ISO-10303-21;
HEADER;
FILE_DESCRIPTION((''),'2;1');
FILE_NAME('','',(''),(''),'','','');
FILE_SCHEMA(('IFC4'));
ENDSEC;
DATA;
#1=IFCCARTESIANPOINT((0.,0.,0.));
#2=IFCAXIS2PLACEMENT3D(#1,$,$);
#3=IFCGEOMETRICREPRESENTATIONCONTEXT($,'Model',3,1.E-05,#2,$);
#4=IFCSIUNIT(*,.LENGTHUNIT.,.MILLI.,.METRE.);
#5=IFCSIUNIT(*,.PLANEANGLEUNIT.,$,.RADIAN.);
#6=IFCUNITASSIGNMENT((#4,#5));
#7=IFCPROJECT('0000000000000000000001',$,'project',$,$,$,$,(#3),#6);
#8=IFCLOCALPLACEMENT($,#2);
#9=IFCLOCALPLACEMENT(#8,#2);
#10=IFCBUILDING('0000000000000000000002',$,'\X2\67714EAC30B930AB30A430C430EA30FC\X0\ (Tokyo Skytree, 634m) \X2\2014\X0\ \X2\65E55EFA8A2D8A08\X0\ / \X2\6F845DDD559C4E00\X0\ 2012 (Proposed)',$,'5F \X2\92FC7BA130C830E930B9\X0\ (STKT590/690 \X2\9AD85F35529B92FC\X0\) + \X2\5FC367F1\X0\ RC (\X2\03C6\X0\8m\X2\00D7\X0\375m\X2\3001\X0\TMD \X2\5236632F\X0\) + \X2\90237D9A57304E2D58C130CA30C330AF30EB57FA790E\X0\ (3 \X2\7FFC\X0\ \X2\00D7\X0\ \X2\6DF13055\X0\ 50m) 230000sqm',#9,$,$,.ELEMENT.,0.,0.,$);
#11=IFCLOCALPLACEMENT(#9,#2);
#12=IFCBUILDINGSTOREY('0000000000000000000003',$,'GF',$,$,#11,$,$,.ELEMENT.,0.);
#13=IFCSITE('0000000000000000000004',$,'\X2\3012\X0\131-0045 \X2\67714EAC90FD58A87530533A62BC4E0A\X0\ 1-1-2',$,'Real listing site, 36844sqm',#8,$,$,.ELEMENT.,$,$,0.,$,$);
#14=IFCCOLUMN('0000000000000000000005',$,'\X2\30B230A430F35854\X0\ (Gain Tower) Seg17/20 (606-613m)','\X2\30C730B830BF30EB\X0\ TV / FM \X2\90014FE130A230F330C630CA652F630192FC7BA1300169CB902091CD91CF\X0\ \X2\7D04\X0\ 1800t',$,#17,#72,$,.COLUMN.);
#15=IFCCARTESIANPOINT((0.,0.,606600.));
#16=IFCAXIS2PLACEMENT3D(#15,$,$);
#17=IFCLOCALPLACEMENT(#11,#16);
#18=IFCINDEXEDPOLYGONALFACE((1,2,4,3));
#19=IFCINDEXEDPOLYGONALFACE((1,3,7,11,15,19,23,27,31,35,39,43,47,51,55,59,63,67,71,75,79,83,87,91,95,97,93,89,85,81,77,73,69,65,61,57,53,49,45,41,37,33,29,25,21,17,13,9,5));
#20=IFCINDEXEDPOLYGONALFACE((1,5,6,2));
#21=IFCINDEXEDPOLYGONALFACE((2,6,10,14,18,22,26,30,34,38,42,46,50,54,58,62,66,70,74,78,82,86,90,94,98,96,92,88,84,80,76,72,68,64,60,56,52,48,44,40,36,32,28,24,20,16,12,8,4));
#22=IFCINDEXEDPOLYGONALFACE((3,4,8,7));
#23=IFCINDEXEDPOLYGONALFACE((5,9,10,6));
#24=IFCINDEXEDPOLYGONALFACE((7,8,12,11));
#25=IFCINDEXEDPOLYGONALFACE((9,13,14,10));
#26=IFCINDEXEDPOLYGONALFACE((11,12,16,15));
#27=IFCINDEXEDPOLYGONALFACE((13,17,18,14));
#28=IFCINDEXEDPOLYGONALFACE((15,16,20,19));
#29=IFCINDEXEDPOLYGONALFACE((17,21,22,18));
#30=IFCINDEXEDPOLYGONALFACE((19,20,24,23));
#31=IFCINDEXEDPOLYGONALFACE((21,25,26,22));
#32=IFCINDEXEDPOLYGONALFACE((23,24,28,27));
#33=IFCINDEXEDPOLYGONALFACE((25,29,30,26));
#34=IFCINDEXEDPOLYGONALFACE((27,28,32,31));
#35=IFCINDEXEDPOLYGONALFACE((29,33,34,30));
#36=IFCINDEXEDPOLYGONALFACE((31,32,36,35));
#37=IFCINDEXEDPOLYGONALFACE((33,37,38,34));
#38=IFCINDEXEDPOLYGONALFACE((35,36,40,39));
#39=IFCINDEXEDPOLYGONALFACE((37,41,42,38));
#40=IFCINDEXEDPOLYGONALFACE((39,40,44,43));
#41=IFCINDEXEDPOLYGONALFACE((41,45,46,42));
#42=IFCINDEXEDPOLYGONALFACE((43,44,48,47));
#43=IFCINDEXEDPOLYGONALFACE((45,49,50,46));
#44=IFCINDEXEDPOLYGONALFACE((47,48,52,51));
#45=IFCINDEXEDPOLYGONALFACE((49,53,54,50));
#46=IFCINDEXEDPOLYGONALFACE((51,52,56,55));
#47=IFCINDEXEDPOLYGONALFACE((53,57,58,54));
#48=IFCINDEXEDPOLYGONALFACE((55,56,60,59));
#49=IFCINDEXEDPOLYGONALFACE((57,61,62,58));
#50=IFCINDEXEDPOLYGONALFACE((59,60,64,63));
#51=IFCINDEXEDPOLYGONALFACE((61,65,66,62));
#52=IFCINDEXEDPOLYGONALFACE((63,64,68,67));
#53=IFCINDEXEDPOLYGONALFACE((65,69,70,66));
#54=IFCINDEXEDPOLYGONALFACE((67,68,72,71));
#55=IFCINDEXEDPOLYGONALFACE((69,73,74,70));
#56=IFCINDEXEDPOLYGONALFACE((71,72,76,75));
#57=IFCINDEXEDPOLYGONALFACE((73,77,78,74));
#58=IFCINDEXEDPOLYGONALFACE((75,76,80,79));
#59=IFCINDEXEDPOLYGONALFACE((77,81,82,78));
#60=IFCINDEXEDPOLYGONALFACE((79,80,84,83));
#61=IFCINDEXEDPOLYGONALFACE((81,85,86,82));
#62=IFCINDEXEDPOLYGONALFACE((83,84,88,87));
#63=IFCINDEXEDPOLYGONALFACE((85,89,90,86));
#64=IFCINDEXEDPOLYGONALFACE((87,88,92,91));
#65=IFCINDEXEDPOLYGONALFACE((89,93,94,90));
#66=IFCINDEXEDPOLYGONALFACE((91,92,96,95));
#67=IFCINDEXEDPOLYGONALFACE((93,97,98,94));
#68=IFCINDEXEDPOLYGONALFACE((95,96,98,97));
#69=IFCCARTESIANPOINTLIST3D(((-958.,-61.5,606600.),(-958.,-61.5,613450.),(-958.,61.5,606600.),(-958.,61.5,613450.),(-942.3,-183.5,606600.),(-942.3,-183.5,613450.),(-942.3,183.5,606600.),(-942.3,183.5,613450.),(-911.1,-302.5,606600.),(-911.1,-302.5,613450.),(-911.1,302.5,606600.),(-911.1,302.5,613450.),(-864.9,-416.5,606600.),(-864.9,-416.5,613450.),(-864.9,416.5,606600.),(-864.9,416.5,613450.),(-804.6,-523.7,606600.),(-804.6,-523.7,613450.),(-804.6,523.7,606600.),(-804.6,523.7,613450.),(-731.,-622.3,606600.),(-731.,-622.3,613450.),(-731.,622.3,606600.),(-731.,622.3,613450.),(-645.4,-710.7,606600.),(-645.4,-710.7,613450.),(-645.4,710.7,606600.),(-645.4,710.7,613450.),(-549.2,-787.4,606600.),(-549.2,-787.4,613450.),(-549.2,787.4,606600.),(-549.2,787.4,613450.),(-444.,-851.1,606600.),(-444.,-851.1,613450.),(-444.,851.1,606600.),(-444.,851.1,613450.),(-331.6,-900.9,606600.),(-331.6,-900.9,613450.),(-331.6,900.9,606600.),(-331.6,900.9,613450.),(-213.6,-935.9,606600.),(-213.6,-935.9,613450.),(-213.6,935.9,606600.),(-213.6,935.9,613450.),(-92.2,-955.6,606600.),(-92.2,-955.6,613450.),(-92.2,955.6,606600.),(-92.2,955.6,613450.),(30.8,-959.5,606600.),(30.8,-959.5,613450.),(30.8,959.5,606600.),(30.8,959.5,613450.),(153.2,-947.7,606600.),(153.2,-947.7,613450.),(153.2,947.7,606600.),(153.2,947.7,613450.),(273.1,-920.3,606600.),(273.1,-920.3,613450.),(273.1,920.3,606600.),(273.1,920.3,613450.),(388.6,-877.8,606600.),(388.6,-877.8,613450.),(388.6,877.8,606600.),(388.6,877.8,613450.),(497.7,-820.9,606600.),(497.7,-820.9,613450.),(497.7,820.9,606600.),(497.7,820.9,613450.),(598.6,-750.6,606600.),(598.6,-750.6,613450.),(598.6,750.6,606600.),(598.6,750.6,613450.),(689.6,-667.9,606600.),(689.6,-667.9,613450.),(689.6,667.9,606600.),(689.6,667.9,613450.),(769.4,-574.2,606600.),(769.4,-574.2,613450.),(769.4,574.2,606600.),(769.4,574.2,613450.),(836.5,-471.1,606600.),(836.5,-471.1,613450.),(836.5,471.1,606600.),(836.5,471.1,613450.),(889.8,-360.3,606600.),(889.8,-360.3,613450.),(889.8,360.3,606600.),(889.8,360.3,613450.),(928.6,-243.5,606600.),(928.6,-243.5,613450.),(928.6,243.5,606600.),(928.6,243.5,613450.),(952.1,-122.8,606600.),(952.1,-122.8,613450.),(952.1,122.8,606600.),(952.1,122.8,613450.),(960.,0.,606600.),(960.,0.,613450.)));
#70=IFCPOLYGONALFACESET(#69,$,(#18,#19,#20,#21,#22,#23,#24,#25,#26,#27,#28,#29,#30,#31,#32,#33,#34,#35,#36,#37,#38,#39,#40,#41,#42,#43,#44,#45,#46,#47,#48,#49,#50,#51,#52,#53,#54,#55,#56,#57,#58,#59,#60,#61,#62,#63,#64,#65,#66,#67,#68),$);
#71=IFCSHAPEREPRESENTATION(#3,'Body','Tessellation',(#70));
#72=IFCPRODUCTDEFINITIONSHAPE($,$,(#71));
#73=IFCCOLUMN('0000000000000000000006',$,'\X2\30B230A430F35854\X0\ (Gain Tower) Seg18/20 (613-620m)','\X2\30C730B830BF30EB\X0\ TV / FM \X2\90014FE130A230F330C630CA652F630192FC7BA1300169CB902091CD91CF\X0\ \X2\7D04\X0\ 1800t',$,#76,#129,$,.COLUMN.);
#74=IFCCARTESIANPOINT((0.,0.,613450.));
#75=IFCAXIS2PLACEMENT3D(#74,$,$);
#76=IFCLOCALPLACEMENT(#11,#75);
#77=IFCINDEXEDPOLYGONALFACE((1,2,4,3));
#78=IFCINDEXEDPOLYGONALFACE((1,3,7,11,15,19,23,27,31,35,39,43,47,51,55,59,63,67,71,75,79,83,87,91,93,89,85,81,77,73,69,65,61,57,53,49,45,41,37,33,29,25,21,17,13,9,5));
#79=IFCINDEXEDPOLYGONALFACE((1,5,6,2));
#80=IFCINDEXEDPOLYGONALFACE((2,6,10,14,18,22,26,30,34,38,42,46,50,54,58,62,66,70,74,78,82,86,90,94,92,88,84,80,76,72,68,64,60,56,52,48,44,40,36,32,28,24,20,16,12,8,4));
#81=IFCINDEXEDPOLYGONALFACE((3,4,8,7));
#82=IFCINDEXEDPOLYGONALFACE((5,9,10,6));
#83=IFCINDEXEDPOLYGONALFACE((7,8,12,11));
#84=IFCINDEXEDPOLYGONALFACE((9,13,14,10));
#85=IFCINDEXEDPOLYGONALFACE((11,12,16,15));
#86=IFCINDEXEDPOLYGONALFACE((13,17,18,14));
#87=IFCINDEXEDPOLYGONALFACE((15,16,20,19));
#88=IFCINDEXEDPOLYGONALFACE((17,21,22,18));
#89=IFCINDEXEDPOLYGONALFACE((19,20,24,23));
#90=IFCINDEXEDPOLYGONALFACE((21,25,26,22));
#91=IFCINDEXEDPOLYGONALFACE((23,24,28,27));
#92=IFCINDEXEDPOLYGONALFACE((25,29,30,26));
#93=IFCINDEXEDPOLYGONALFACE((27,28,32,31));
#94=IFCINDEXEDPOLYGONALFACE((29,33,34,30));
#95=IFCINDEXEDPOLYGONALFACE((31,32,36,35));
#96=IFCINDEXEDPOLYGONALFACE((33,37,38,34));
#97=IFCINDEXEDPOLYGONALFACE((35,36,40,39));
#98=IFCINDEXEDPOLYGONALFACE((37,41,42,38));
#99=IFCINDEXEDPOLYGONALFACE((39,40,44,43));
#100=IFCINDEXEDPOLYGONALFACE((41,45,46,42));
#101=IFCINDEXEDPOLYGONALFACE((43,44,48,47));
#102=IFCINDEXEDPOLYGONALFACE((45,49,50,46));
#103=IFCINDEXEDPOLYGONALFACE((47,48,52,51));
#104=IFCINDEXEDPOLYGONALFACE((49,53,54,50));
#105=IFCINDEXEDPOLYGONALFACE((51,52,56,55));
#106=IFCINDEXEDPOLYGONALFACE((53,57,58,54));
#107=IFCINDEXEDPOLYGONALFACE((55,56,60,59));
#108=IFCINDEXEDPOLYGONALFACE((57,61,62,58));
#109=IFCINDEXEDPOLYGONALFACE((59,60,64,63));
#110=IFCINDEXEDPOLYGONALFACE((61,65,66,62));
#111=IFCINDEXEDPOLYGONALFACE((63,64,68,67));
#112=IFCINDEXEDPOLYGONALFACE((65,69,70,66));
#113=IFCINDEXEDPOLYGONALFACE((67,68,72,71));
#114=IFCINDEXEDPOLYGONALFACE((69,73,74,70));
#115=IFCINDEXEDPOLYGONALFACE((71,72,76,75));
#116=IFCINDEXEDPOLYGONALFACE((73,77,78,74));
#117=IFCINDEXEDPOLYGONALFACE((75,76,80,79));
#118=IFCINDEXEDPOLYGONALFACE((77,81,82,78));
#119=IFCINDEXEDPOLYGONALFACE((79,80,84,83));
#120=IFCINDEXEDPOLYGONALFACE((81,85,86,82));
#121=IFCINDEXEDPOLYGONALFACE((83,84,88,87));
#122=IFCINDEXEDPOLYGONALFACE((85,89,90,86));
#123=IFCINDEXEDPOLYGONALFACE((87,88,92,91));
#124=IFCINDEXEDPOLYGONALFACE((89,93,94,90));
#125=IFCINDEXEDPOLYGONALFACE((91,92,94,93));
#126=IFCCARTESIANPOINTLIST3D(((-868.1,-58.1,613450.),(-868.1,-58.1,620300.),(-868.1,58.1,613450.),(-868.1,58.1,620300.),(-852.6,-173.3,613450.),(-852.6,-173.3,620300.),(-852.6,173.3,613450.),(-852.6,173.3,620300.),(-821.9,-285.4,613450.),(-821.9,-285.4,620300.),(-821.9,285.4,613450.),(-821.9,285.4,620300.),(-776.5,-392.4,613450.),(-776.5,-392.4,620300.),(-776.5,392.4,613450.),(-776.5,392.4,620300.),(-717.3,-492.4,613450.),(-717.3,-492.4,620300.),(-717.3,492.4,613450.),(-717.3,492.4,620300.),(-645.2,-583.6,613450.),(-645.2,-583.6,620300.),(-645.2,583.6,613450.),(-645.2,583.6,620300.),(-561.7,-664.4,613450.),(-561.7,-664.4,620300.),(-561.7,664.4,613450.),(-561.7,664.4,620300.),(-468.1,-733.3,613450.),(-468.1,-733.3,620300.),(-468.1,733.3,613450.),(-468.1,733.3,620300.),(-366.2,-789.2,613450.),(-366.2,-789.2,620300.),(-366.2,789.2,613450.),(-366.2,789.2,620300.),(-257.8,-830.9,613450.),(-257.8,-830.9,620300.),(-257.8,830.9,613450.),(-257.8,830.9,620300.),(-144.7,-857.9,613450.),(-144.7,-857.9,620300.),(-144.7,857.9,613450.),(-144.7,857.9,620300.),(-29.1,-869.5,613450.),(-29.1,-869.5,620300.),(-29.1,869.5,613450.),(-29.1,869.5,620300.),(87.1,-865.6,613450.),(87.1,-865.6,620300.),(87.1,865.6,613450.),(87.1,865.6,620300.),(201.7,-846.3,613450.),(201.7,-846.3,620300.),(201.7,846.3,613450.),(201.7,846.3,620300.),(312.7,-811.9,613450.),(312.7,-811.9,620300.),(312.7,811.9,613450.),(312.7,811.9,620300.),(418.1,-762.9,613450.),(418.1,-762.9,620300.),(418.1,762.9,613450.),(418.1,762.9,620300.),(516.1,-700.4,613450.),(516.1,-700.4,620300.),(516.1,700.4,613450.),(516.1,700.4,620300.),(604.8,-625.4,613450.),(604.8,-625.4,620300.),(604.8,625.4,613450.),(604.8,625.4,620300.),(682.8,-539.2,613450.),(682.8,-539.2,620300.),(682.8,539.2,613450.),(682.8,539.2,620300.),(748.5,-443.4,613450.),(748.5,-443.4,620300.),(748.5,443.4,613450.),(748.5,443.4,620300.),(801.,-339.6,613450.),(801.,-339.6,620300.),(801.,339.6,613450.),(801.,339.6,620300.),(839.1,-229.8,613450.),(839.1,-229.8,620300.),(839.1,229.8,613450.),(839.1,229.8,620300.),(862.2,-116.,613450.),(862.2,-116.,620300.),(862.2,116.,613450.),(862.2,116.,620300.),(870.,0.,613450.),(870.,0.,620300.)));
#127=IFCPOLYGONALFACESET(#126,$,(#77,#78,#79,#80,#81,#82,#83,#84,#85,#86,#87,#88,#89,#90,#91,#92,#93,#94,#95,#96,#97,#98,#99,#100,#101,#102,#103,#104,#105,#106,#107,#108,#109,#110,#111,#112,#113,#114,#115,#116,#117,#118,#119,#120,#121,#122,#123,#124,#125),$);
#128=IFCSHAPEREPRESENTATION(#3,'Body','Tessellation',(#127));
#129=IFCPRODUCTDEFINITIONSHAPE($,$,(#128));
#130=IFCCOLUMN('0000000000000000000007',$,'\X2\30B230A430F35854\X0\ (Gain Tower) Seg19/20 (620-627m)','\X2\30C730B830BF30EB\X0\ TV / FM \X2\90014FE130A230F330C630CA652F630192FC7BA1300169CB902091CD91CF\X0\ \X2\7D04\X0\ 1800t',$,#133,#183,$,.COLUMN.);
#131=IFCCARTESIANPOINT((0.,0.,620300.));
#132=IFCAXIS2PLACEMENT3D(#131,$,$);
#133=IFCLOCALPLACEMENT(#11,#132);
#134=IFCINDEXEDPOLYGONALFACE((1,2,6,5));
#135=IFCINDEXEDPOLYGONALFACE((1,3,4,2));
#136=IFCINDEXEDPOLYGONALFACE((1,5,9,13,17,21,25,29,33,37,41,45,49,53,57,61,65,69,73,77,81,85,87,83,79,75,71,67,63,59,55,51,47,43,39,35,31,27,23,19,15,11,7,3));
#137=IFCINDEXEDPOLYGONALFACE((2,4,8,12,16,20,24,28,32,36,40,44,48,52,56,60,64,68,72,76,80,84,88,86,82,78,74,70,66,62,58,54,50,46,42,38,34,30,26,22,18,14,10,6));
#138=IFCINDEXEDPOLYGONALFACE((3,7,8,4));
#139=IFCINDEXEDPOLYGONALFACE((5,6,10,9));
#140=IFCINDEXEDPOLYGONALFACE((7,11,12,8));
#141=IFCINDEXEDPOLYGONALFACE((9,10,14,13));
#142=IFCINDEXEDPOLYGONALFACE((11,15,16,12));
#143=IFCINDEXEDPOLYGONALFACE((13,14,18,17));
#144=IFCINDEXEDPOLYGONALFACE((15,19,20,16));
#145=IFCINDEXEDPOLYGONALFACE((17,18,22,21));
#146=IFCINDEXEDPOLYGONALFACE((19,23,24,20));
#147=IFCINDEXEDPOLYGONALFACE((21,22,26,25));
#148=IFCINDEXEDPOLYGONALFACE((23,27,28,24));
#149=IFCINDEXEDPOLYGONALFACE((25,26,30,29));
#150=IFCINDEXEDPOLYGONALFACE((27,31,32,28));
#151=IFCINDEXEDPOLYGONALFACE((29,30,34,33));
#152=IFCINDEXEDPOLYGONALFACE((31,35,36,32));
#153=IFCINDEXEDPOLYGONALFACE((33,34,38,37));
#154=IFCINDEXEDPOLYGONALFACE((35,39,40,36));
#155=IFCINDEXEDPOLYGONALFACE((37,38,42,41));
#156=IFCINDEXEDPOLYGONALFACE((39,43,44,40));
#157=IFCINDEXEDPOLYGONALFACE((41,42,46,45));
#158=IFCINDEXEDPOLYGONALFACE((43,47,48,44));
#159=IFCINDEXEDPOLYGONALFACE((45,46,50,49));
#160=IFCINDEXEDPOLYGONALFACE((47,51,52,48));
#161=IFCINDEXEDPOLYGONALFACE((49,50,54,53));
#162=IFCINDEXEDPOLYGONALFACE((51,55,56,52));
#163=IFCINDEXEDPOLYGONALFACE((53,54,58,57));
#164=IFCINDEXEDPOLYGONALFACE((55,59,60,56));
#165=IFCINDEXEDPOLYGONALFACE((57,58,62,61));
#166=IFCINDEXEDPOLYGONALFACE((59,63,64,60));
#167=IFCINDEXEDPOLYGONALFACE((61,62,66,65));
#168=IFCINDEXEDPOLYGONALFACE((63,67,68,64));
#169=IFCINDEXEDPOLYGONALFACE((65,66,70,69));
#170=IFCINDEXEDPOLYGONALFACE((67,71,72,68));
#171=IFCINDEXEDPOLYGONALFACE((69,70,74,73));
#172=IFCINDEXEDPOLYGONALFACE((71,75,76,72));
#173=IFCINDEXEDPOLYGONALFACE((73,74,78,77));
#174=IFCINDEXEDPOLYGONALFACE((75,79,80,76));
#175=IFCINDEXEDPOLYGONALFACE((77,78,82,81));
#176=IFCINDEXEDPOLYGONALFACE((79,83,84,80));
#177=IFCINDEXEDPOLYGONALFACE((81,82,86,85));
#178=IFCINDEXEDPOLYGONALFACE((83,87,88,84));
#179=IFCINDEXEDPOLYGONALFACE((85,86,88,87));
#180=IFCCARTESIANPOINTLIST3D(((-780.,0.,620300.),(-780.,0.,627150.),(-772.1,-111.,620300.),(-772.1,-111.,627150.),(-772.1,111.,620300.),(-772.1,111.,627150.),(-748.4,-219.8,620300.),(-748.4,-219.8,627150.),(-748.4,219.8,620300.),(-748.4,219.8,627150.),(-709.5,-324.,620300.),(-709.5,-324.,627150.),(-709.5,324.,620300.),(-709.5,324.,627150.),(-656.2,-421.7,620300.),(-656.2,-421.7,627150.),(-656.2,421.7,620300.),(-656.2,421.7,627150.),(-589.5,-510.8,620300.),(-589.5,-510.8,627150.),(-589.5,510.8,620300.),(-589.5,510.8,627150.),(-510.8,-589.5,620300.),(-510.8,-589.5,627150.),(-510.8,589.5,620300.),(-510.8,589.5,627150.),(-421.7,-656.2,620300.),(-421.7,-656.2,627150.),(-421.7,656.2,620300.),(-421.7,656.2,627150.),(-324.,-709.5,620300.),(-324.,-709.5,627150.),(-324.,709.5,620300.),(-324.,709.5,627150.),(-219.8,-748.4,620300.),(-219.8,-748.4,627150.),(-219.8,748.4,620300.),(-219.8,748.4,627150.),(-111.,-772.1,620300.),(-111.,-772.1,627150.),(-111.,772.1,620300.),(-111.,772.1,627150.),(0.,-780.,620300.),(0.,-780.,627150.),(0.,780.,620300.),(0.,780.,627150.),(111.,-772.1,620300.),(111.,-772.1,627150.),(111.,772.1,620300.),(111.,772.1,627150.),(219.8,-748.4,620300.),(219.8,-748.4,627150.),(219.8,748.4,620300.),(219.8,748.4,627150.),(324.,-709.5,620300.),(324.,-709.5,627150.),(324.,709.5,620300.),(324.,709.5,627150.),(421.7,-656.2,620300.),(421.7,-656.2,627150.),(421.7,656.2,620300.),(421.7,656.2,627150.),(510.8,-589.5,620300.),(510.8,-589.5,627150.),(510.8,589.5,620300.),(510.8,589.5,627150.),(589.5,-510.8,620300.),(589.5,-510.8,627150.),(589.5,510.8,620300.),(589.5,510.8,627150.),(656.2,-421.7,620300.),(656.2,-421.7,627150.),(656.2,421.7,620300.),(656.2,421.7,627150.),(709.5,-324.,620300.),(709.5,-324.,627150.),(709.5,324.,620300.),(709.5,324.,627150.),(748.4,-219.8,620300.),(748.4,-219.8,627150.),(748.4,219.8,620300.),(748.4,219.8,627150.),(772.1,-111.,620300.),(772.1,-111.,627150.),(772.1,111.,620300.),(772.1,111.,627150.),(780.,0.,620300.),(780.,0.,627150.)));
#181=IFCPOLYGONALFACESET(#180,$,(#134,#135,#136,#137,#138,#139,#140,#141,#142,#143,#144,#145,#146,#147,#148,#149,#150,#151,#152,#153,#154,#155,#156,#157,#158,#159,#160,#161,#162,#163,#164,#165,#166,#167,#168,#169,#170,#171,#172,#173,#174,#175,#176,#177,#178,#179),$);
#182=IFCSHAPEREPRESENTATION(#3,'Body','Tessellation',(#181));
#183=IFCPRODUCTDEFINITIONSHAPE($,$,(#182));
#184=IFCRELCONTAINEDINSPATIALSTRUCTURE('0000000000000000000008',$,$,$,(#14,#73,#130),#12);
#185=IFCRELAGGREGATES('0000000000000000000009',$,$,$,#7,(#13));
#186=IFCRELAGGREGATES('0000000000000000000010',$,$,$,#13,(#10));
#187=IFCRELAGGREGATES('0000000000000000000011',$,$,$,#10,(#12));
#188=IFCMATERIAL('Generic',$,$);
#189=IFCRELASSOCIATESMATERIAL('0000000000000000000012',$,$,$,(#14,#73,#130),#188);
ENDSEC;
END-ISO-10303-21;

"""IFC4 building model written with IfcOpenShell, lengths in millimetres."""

from ifc_helpers import new_model, si_unit, frame, origin, origin_2d, place, context, project, spatial, circle, extrude, material, element, save


model = new_model("IFC4")

# Units and contexts
model_context = context("Model", 3, precision=1e-05, world=origin())
ifc_project = project(units=[si_unit("LENGTHUNIT", "METRE", prefix="MILLI"), si_unit("PLANEANGLEUNIT", "RADIAN")], contexts=[model_context])

# Site, building, storey
site_placement = place(None, origin())
site = spatial("IfcSite", under=ifc_project, at=site_placement, Name="〒131-0045 東京都墨田区押上 1-1-2", ObjectType="Real listing site, 36844sqm", CompositionType="ELEMENT", RefElevation=0.0)
building_placement = place(site_placement, origin())
building = spatial("IfcBuilding", under=site, at=building_placement, Name="東京スカイツリー (Tokyo Skytree, 634m) — 日建設計 / 澄川喜一 2012 (Proposed)", ObjectType="5F 鋼管トラス (STKT590/690 高張力鋼) + 心柱 RC (φ8m×375m、TMD 制振) + 連続地中壁ナックル基礎 (3 翼 × 深さ 50m) 230000sqm", CompositionType="ELEMENT", ElevationOfRefHeight=0.0, ElevationOfTerrain=0.0)
storey_placement = place(building_placement, origin())
storey = spatial("IfcBuildingStorey", under=building, at=storey_placement, Name="GF", CompositionType="ELEMENT", Elevation=0.0)

# Columns
ifc_material = material(Name="Generic")
column_1_placement = place(storey_placement, frame((0.0, 0.0, 606600.0)))
element("IfcColumn", 1, at=column_1_placement, inside=storey, material=ifc_material, Name="ゲイン塔 (Gain Tower) Seg17/20 (606-613m)", Description="デジタル TV / FM 送信アンテナ支持鋼管、構造重量 約 1800t", PredefinedType="COLUMN", context=model_context, shape_type="SweptSolid", body=[
    extrude(circle(Radius=960.0, at=origin_2d()), frame((0.0, 0.0, 606600.0)), (0.0, 0.0, 1.0), 6850.0),
])
column_2_placement = place(storey_placement, frame((0.0, 0.0, 613450.0)))
element("IfcColumn", 2, at=column_2_placement, inside=storey, material=ifc_material, Name="ゲイン塔 (Gain Tower) Seg18/20 (613-620m)", Description="デジタル TV / FM 送信アンテナ支持鋼管、構造重量 約 1800t", PredefinedType="COLUMN", context=model_context, shape_type="SweptSolid", body=[
    extrude(circle(Radius=870.0, at=origin_2d()), frame((0.0, 0.0, 613450.0)), (0.0, 0.0, 1.0), 6850.0),
])
column_3_placement = place(storey_placement, frame((0.0, 0.0, 620300.0)))
element("IfcColumn", 3, at=column_3_placement, inside=storey, material=ifc_material, Name="ゲイン塔 (Gain Tower) Seg19/20 (620-627m)", Description="デジタル TV / FM 送信アンテナ支持鋼管、構造重量 約 1800t", PredefinedType="COLUMN", context=model_context, shape_type="SweptSolid", body=[
    extrude(circle(Radius=780.0, at=origin_2d()), frame((0.0, 0.0, 620300.0)), (0.0, 0.0, 1.0), 6850.0),
])

save(model, "model.ifc")
